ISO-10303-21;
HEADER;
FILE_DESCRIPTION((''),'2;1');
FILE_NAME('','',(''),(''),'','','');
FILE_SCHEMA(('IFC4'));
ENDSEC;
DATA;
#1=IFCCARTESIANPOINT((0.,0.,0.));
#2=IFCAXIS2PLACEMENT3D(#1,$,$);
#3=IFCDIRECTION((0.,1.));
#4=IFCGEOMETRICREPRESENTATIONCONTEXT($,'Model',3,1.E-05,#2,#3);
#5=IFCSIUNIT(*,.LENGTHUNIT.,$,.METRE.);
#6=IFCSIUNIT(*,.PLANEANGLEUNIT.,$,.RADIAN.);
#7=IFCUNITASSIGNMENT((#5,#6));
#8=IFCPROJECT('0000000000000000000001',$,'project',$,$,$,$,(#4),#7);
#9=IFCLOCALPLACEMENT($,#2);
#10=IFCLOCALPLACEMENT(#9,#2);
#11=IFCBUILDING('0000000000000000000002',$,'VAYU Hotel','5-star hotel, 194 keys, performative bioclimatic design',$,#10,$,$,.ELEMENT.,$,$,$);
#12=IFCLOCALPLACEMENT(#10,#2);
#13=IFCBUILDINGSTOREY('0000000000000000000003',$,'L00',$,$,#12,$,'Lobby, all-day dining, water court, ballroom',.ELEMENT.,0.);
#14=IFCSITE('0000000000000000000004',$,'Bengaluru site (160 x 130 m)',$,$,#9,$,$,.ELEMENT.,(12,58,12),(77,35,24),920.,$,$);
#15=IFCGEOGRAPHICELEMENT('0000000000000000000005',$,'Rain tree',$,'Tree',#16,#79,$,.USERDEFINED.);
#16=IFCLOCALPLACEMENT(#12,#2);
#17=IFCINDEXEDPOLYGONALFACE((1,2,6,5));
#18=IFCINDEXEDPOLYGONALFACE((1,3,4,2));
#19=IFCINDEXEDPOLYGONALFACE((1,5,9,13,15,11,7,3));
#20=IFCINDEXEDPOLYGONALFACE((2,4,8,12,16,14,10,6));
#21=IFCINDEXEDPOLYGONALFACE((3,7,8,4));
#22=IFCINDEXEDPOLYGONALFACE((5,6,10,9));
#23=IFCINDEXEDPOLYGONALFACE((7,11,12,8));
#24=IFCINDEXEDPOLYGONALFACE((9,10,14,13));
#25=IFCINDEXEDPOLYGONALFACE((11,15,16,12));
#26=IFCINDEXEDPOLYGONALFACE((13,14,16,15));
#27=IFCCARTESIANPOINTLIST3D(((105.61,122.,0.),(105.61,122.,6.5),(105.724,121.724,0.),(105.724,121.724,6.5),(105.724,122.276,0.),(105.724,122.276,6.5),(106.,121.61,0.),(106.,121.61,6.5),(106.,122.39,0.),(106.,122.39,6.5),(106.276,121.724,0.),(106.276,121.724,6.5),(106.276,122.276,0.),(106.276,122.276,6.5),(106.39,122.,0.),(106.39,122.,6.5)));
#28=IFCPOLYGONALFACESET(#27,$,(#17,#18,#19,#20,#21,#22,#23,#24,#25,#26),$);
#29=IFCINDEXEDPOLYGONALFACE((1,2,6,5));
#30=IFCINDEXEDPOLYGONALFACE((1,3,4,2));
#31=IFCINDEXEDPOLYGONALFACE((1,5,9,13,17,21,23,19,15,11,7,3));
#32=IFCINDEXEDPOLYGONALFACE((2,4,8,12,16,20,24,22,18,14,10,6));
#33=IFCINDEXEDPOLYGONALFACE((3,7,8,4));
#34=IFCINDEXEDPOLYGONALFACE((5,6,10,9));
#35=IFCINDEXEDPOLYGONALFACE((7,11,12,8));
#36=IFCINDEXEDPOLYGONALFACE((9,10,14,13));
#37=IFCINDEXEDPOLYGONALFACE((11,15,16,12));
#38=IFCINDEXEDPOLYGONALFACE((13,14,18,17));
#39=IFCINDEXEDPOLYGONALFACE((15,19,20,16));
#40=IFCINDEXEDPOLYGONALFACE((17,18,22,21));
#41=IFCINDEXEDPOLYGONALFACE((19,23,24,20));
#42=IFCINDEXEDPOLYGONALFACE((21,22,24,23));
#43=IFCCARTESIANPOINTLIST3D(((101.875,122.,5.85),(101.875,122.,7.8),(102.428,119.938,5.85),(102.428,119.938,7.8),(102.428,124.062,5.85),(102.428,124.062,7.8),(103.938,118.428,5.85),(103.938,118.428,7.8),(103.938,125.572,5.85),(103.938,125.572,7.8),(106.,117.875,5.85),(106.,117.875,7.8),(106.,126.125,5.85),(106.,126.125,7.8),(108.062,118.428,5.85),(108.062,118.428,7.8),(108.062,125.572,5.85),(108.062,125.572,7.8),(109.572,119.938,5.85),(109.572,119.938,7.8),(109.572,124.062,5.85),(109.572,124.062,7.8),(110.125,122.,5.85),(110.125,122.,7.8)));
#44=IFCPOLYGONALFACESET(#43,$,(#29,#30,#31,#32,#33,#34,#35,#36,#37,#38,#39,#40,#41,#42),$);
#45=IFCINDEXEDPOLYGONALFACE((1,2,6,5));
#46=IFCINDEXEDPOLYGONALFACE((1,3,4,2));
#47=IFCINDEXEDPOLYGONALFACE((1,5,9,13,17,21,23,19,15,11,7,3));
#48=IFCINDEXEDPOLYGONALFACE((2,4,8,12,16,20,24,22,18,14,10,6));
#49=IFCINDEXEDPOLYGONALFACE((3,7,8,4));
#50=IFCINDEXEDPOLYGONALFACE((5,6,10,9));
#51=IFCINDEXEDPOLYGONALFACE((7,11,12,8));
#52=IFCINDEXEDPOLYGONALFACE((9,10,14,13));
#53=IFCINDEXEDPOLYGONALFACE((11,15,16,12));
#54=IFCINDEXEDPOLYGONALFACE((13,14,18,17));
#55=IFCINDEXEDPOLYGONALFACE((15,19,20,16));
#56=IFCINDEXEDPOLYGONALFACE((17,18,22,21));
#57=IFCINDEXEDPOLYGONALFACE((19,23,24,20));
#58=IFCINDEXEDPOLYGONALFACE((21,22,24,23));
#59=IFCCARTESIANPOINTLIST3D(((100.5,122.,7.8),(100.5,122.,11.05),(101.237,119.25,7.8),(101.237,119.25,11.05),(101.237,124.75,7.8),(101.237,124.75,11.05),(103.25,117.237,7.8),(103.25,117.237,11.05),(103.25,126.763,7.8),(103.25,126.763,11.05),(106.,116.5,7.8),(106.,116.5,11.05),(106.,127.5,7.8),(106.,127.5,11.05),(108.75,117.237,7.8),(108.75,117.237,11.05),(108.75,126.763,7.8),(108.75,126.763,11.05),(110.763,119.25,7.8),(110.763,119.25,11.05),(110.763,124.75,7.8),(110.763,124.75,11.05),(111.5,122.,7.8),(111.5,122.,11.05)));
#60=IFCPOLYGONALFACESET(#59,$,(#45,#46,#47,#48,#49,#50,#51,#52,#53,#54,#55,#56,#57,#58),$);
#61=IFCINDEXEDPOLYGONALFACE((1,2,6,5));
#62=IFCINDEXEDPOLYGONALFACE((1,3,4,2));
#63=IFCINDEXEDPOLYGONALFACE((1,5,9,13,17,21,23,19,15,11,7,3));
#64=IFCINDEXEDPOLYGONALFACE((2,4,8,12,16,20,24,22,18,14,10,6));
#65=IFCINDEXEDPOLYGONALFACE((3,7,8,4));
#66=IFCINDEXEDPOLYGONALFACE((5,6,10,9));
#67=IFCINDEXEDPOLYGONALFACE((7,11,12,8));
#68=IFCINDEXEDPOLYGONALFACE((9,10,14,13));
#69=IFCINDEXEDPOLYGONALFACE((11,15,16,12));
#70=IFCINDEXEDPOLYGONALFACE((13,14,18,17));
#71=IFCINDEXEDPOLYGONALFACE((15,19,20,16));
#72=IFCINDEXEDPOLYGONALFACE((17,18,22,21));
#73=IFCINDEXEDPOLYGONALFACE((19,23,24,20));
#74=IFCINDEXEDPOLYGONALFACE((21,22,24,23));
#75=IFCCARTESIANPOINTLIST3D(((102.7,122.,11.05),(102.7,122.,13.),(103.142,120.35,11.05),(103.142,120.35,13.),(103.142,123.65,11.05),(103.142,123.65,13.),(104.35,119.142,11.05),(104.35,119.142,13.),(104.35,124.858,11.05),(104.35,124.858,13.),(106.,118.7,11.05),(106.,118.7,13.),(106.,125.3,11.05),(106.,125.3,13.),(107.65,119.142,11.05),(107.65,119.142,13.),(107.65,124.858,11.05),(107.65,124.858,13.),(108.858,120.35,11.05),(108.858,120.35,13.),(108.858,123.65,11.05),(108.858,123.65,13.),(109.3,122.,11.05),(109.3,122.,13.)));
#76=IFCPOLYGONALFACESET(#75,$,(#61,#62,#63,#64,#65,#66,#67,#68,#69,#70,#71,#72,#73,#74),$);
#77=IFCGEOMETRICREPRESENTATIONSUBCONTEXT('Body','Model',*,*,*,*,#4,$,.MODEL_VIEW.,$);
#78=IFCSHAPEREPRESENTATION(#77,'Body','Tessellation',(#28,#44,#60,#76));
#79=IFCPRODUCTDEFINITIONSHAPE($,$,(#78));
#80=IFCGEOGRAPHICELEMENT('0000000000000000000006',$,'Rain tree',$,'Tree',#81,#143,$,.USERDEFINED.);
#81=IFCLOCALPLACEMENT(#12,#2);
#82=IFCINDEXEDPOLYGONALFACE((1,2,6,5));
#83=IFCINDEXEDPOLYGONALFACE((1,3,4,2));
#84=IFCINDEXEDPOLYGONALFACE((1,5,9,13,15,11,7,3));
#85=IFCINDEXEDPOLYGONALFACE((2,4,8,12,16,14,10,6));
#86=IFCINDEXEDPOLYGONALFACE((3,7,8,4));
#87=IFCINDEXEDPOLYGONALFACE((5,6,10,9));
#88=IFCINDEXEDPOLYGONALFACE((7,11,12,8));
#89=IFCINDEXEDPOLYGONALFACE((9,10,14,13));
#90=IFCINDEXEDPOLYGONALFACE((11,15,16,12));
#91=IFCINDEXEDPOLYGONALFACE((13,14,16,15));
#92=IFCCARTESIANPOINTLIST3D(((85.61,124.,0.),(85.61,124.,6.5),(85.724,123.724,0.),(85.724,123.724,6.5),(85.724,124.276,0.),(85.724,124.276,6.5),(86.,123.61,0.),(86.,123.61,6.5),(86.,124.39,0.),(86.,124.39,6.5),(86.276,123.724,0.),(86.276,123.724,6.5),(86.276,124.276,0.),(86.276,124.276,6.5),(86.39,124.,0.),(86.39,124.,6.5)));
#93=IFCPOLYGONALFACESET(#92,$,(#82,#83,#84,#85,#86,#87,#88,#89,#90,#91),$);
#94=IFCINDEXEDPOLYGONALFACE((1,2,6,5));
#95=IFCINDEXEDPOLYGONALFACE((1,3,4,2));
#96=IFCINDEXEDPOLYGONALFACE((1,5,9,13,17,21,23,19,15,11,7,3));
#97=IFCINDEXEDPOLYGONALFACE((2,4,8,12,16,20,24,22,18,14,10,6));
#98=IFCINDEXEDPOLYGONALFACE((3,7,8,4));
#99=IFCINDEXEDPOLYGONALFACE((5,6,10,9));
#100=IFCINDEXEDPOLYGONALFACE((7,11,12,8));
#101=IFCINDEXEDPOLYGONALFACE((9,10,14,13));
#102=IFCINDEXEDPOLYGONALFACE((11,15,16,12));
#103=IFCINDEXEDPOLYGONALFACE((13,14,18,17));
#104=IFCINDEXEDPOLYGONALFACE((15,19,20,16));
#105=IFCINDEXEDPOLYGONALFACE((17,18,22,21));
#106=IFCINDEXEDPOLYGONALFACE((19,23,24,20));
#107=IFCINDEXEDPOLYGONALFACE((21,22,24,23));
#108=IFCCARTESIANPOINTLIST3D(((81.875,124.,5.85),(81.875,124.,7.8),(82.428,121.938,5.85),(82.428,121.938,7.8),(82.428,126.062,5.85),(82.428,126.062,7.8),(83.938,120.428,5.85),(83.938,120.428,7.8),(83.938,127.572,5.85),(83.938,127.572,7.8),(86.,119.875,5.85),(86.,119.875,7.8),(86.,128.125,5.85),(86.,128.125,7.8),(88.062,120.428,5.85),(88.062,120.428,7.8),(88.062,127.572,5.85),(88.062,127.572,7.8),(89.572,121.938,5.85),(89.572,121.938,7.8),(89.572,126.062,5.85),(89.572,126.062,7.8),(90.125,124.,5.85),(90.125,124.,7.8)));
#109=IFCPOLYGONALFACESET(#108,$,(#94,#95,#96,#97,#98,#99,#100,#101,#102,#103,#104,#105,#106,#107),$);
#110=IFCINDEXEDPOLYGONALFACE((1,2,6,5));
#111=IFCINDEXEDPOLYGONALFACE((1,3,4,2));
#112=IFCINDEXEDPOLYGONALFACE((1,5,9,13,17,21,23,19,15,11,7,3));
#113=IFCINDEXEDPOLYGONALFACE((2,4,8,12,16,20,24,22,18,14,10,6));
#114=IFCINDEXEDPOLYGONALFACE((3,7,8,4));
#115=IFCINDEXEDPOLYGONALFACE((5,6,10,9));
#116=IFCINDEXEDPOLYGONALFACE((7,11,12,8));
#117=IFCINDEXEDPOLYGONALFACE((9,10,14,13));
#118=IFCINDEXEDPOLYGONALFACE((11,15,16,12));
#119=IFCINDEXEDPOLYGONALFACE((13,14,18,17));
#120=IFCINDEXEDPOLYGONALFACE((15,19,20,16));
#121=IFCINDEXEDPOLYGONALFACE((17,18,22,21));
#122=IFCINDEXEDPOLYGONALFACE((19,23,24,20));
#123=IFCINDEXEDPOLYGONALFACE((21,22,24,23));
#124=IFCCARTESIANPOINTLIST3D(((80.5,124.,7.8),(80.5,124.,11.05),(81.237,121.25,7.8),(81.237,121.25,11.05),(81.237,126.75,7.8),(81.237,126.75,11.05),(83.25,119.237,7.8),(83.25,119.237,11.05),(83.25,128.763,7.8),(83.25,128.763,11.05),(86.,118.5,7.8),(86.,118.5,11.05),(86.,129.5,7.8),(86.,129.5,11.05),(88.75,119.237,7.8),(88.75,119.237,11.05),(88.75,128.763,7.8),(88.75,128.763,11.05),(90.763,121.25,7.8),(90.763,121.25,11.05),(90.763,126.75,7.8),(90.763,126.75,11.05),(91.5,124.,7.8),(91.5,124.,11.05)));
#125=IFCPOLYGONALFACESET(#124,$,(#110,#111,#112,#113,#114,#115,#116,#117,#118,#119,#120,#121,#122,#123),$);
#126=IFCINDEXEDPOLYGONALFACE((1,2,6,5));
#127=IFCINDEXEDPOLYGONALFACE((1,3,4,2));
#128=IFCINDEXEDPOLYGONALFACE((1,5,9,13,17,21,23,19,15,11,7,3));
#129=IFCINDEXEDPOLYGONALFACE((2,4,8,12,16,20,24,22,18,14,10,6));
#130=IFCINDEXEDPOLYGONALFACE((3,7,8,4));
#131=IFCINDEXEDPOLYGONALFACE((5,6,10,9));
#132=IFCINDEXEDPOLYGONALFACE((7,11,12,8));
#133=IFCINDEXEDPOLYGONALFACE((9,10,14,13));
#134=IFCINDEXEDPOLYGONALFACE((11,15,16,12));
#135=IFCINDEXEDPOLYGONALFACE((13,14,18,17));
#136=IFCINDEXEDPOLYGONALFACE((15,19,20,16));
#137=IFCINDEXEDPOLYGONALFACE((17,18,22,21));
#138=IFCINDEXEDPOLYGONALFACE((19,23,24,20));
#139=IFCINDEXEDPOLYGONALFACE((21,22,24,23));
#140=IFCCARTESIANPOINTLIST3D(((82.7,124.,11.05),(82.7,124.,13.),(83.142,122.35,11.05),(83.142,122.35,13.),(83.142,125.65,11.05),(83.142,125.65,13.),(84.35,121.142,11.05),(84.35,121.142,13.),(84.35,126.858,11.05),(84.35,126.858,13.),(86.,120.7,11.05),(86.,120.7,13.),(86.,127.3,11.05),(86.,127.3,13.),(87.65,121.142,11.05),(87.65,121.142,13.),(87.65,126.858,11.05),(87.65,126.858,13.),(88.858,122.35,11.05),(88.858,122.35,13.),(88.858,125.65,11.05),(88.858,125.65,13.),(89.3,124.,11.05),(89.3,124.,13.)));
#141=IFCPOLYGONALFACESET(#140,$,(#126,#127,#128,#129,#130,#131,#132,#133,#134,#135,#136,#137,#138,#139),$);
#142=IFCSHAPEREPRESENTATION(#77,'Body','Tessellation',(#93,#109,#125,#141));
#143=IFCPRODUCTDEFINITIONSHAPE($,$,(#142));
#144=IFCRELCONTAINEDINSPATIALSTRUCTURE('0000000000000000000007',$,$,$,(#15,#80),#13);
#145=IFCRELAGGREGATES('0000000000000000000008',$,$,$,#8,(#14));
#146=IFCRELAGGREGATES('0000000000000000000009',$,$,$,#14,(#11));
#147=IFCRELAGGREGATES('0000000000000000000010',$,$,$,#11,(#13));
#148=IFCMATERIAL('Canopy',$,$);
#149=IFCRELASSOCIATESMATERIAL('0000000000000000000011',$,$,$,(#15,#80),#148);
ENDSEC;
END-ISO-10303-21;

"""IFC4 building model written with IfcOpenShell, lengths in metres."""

from ifc_helpers import new_model, si_unit, direction, frame, origin, place, context, subcontext, project, spatial, polyline, outline, extrude, material, element, save


model = new_model("IFC4")

# Units and contexts
model_context = context("Model", 3, precision=1e-05, world=origin(), true_north=direction((0.0, 1.0)))
body_context = subcontext(model_context, "Body", "Model", "MODEL_VIEW")
ifc_project = project(units=[si_unit("LENGTHUNIT", "METRE"), si_unit("PLANEANGLEUNIT", "RADIAN")], contexts=[model_context])

# Site, building, storey
site_placement = place(None, origin())
site = spatial("IfcSite", under=ifc_project, at=site_placement, Name="Bengaluru site (160 x 130 m)", CompositionType="ELEMENT", RefLatitude=(12, 58, 12), RefLongitude=(77, 35, 24), RefElevation=920.0)
building_placement = place(site_placement, origin())
building = spatial("IfcBuilding", under=site, at=building_placement, Name="VAYU Hotel", Description="5-star hotel, 194 keys, performative bioclimatic design", CompositionType="ELEMENT")
storey_placement = place(building_placement, origin())
storey = spatial("IfcBuildingStorey", under=building, at=storey_placement, Name="L00", LongName="Lobby, all-day dining, water court, ballroom", CompositionType="ELEMENT", Elevation=0.0)

# Geographic elements
ifc_material_1 = material(Name="Canopy")
geographic_element_1_placement = place(storey_placement, origin())
element("IfcGeographicElement", 1, at=geographic_element_1_placement, inside=storey, material=ifc_material_1, Name="Rain tree", ObjectType="Tree", PredefinedType="USERDEFINED", context=body_context, shape_type="SweptSolid", body=[
    extrude(outline(polyline([(106.39, 122.0), (106.276, 122.276), (106.0, 122.39), (105.724, 122.276), (105.61, 122.0), (105.724, 121.724), (106.0, 121.61), (106.276, 121.724), (106.39, 122.0)])), origin(), (0.0, 0.0, 1.0), 6.5),
    extrude(outline(polyline([(110.125, 122.0), (109.572, 124.062), (108.062, 125.572), (106.0, 126.125), (103.938, 125.572), (102.428, 124.062), (101.875, 122.0), (102.428, 119.938), (103.938, 118.428), (106.0, 117.875), (108.062, 118.428), (109.572, 119.938), (110.125, 122.0)])), frame((0.0, 0.0, 5.85)), (0.0, 0.0, 1.0), 1.95),
    extrude(outline(polyline([(111.5, 122.0), (110.763, 124.75), (108.75, 126.763), (106.0, 127.5), (103.25, 126.763), (101.237, 124.75), (100.5, 122.0), (101.237, 119.25), (103.25, 117.237), (106.0, 116.5), (108.75, 117.237), (110.763, 119.25), (111.5, 122.0)])), frame((0.0, 0.0, 7.8)), (0.0, 0.0, 1.0), 3.25),
    extrude(outline(polyline([(109.3, 122.0), (108.858, 123.65), (107.65, 124.858), (106.0, 125.3), (104.35, 124.858), (103.142, 123.65), (102.7, 122.0), (103.142, 120.35), (104.35, 119.142), (106.0, 118.7), (107.65, 119.142), (108.858, 120.35), (109.3, 122.0)])), frame((0.0, 0.0, 11.05)), (0.0, 0.0, 1.0), 1.95),
])
geographic_element_2_placement = place(storey_placement, origin())
element("IfcGeographicElement", 2, at=geographic_element_2_placement, inside=storey, material=ifc_material_1, Name="Rain tree", ObjectType="Tree", PredefinedType="USERDEFINED", context=body_context, shape_type="SweptSolid", body=[
    extrude(outline(polyline([(86.39, 124.0), (86.276, 124.276), (86.0, 124.39), (85.724, 124.276), (85.61, 124.0), (85.724, 123.724), (86.0, 123.61), (86.276, 123.724), (86.39, 124.0)])), origin(), (0.0, 0.0, 1.0), 6.5),
    extrude(outline(polyline([(90.125, 124.0), (89.572, 126.062), (88.062, 127.572), (86.0, 128.125), (83.938, 127.572), (82.428, 126.062), (81.875, 124.0), (82.428, 121.938), (83.938, 120.428), (86.0, 119.875), (88.062, 120.428), (89.572, 121.938), (90.125, 124.0)])), frame((0.0, 0.0, 5.85)), (0.0, 0.0, 1.0), 1.95),
    extrude(outline(polyline([(91.5, 124.0), (90.763, 126.75), (88.75, 128.763), (86.0, 129.5), (83.25, 128.763), (81.237, 126.75), (80.5, 124.0), (81.237, 121.25), (83.25, 119.237), (86.0, 118.5), (88.75, 119.237), (90.763, 121.25), (91.5, 124.0)])), frame((0.0, 0.0, 7.8)), (0.0, 0.0, 1.0), 3.25),
    extrude(outline(polyline([(89.3, 124.0), (88.858, 125.65), (87.65, 126.858), (86.0, 127.3), (84.35, 126.858), (83.142, 125.65), (82.7, 124.0), (83.142, 122.35), (84.35, 121.142), (86.0, 120.7), (87.65, 121.142), (88.858, 122.35), (89.3, 124.0)])), frame((0.0, 0.0, 11.05)), (0.0, 0.0, 1.0), 1.95),
])

save(model, "model.ifc")
